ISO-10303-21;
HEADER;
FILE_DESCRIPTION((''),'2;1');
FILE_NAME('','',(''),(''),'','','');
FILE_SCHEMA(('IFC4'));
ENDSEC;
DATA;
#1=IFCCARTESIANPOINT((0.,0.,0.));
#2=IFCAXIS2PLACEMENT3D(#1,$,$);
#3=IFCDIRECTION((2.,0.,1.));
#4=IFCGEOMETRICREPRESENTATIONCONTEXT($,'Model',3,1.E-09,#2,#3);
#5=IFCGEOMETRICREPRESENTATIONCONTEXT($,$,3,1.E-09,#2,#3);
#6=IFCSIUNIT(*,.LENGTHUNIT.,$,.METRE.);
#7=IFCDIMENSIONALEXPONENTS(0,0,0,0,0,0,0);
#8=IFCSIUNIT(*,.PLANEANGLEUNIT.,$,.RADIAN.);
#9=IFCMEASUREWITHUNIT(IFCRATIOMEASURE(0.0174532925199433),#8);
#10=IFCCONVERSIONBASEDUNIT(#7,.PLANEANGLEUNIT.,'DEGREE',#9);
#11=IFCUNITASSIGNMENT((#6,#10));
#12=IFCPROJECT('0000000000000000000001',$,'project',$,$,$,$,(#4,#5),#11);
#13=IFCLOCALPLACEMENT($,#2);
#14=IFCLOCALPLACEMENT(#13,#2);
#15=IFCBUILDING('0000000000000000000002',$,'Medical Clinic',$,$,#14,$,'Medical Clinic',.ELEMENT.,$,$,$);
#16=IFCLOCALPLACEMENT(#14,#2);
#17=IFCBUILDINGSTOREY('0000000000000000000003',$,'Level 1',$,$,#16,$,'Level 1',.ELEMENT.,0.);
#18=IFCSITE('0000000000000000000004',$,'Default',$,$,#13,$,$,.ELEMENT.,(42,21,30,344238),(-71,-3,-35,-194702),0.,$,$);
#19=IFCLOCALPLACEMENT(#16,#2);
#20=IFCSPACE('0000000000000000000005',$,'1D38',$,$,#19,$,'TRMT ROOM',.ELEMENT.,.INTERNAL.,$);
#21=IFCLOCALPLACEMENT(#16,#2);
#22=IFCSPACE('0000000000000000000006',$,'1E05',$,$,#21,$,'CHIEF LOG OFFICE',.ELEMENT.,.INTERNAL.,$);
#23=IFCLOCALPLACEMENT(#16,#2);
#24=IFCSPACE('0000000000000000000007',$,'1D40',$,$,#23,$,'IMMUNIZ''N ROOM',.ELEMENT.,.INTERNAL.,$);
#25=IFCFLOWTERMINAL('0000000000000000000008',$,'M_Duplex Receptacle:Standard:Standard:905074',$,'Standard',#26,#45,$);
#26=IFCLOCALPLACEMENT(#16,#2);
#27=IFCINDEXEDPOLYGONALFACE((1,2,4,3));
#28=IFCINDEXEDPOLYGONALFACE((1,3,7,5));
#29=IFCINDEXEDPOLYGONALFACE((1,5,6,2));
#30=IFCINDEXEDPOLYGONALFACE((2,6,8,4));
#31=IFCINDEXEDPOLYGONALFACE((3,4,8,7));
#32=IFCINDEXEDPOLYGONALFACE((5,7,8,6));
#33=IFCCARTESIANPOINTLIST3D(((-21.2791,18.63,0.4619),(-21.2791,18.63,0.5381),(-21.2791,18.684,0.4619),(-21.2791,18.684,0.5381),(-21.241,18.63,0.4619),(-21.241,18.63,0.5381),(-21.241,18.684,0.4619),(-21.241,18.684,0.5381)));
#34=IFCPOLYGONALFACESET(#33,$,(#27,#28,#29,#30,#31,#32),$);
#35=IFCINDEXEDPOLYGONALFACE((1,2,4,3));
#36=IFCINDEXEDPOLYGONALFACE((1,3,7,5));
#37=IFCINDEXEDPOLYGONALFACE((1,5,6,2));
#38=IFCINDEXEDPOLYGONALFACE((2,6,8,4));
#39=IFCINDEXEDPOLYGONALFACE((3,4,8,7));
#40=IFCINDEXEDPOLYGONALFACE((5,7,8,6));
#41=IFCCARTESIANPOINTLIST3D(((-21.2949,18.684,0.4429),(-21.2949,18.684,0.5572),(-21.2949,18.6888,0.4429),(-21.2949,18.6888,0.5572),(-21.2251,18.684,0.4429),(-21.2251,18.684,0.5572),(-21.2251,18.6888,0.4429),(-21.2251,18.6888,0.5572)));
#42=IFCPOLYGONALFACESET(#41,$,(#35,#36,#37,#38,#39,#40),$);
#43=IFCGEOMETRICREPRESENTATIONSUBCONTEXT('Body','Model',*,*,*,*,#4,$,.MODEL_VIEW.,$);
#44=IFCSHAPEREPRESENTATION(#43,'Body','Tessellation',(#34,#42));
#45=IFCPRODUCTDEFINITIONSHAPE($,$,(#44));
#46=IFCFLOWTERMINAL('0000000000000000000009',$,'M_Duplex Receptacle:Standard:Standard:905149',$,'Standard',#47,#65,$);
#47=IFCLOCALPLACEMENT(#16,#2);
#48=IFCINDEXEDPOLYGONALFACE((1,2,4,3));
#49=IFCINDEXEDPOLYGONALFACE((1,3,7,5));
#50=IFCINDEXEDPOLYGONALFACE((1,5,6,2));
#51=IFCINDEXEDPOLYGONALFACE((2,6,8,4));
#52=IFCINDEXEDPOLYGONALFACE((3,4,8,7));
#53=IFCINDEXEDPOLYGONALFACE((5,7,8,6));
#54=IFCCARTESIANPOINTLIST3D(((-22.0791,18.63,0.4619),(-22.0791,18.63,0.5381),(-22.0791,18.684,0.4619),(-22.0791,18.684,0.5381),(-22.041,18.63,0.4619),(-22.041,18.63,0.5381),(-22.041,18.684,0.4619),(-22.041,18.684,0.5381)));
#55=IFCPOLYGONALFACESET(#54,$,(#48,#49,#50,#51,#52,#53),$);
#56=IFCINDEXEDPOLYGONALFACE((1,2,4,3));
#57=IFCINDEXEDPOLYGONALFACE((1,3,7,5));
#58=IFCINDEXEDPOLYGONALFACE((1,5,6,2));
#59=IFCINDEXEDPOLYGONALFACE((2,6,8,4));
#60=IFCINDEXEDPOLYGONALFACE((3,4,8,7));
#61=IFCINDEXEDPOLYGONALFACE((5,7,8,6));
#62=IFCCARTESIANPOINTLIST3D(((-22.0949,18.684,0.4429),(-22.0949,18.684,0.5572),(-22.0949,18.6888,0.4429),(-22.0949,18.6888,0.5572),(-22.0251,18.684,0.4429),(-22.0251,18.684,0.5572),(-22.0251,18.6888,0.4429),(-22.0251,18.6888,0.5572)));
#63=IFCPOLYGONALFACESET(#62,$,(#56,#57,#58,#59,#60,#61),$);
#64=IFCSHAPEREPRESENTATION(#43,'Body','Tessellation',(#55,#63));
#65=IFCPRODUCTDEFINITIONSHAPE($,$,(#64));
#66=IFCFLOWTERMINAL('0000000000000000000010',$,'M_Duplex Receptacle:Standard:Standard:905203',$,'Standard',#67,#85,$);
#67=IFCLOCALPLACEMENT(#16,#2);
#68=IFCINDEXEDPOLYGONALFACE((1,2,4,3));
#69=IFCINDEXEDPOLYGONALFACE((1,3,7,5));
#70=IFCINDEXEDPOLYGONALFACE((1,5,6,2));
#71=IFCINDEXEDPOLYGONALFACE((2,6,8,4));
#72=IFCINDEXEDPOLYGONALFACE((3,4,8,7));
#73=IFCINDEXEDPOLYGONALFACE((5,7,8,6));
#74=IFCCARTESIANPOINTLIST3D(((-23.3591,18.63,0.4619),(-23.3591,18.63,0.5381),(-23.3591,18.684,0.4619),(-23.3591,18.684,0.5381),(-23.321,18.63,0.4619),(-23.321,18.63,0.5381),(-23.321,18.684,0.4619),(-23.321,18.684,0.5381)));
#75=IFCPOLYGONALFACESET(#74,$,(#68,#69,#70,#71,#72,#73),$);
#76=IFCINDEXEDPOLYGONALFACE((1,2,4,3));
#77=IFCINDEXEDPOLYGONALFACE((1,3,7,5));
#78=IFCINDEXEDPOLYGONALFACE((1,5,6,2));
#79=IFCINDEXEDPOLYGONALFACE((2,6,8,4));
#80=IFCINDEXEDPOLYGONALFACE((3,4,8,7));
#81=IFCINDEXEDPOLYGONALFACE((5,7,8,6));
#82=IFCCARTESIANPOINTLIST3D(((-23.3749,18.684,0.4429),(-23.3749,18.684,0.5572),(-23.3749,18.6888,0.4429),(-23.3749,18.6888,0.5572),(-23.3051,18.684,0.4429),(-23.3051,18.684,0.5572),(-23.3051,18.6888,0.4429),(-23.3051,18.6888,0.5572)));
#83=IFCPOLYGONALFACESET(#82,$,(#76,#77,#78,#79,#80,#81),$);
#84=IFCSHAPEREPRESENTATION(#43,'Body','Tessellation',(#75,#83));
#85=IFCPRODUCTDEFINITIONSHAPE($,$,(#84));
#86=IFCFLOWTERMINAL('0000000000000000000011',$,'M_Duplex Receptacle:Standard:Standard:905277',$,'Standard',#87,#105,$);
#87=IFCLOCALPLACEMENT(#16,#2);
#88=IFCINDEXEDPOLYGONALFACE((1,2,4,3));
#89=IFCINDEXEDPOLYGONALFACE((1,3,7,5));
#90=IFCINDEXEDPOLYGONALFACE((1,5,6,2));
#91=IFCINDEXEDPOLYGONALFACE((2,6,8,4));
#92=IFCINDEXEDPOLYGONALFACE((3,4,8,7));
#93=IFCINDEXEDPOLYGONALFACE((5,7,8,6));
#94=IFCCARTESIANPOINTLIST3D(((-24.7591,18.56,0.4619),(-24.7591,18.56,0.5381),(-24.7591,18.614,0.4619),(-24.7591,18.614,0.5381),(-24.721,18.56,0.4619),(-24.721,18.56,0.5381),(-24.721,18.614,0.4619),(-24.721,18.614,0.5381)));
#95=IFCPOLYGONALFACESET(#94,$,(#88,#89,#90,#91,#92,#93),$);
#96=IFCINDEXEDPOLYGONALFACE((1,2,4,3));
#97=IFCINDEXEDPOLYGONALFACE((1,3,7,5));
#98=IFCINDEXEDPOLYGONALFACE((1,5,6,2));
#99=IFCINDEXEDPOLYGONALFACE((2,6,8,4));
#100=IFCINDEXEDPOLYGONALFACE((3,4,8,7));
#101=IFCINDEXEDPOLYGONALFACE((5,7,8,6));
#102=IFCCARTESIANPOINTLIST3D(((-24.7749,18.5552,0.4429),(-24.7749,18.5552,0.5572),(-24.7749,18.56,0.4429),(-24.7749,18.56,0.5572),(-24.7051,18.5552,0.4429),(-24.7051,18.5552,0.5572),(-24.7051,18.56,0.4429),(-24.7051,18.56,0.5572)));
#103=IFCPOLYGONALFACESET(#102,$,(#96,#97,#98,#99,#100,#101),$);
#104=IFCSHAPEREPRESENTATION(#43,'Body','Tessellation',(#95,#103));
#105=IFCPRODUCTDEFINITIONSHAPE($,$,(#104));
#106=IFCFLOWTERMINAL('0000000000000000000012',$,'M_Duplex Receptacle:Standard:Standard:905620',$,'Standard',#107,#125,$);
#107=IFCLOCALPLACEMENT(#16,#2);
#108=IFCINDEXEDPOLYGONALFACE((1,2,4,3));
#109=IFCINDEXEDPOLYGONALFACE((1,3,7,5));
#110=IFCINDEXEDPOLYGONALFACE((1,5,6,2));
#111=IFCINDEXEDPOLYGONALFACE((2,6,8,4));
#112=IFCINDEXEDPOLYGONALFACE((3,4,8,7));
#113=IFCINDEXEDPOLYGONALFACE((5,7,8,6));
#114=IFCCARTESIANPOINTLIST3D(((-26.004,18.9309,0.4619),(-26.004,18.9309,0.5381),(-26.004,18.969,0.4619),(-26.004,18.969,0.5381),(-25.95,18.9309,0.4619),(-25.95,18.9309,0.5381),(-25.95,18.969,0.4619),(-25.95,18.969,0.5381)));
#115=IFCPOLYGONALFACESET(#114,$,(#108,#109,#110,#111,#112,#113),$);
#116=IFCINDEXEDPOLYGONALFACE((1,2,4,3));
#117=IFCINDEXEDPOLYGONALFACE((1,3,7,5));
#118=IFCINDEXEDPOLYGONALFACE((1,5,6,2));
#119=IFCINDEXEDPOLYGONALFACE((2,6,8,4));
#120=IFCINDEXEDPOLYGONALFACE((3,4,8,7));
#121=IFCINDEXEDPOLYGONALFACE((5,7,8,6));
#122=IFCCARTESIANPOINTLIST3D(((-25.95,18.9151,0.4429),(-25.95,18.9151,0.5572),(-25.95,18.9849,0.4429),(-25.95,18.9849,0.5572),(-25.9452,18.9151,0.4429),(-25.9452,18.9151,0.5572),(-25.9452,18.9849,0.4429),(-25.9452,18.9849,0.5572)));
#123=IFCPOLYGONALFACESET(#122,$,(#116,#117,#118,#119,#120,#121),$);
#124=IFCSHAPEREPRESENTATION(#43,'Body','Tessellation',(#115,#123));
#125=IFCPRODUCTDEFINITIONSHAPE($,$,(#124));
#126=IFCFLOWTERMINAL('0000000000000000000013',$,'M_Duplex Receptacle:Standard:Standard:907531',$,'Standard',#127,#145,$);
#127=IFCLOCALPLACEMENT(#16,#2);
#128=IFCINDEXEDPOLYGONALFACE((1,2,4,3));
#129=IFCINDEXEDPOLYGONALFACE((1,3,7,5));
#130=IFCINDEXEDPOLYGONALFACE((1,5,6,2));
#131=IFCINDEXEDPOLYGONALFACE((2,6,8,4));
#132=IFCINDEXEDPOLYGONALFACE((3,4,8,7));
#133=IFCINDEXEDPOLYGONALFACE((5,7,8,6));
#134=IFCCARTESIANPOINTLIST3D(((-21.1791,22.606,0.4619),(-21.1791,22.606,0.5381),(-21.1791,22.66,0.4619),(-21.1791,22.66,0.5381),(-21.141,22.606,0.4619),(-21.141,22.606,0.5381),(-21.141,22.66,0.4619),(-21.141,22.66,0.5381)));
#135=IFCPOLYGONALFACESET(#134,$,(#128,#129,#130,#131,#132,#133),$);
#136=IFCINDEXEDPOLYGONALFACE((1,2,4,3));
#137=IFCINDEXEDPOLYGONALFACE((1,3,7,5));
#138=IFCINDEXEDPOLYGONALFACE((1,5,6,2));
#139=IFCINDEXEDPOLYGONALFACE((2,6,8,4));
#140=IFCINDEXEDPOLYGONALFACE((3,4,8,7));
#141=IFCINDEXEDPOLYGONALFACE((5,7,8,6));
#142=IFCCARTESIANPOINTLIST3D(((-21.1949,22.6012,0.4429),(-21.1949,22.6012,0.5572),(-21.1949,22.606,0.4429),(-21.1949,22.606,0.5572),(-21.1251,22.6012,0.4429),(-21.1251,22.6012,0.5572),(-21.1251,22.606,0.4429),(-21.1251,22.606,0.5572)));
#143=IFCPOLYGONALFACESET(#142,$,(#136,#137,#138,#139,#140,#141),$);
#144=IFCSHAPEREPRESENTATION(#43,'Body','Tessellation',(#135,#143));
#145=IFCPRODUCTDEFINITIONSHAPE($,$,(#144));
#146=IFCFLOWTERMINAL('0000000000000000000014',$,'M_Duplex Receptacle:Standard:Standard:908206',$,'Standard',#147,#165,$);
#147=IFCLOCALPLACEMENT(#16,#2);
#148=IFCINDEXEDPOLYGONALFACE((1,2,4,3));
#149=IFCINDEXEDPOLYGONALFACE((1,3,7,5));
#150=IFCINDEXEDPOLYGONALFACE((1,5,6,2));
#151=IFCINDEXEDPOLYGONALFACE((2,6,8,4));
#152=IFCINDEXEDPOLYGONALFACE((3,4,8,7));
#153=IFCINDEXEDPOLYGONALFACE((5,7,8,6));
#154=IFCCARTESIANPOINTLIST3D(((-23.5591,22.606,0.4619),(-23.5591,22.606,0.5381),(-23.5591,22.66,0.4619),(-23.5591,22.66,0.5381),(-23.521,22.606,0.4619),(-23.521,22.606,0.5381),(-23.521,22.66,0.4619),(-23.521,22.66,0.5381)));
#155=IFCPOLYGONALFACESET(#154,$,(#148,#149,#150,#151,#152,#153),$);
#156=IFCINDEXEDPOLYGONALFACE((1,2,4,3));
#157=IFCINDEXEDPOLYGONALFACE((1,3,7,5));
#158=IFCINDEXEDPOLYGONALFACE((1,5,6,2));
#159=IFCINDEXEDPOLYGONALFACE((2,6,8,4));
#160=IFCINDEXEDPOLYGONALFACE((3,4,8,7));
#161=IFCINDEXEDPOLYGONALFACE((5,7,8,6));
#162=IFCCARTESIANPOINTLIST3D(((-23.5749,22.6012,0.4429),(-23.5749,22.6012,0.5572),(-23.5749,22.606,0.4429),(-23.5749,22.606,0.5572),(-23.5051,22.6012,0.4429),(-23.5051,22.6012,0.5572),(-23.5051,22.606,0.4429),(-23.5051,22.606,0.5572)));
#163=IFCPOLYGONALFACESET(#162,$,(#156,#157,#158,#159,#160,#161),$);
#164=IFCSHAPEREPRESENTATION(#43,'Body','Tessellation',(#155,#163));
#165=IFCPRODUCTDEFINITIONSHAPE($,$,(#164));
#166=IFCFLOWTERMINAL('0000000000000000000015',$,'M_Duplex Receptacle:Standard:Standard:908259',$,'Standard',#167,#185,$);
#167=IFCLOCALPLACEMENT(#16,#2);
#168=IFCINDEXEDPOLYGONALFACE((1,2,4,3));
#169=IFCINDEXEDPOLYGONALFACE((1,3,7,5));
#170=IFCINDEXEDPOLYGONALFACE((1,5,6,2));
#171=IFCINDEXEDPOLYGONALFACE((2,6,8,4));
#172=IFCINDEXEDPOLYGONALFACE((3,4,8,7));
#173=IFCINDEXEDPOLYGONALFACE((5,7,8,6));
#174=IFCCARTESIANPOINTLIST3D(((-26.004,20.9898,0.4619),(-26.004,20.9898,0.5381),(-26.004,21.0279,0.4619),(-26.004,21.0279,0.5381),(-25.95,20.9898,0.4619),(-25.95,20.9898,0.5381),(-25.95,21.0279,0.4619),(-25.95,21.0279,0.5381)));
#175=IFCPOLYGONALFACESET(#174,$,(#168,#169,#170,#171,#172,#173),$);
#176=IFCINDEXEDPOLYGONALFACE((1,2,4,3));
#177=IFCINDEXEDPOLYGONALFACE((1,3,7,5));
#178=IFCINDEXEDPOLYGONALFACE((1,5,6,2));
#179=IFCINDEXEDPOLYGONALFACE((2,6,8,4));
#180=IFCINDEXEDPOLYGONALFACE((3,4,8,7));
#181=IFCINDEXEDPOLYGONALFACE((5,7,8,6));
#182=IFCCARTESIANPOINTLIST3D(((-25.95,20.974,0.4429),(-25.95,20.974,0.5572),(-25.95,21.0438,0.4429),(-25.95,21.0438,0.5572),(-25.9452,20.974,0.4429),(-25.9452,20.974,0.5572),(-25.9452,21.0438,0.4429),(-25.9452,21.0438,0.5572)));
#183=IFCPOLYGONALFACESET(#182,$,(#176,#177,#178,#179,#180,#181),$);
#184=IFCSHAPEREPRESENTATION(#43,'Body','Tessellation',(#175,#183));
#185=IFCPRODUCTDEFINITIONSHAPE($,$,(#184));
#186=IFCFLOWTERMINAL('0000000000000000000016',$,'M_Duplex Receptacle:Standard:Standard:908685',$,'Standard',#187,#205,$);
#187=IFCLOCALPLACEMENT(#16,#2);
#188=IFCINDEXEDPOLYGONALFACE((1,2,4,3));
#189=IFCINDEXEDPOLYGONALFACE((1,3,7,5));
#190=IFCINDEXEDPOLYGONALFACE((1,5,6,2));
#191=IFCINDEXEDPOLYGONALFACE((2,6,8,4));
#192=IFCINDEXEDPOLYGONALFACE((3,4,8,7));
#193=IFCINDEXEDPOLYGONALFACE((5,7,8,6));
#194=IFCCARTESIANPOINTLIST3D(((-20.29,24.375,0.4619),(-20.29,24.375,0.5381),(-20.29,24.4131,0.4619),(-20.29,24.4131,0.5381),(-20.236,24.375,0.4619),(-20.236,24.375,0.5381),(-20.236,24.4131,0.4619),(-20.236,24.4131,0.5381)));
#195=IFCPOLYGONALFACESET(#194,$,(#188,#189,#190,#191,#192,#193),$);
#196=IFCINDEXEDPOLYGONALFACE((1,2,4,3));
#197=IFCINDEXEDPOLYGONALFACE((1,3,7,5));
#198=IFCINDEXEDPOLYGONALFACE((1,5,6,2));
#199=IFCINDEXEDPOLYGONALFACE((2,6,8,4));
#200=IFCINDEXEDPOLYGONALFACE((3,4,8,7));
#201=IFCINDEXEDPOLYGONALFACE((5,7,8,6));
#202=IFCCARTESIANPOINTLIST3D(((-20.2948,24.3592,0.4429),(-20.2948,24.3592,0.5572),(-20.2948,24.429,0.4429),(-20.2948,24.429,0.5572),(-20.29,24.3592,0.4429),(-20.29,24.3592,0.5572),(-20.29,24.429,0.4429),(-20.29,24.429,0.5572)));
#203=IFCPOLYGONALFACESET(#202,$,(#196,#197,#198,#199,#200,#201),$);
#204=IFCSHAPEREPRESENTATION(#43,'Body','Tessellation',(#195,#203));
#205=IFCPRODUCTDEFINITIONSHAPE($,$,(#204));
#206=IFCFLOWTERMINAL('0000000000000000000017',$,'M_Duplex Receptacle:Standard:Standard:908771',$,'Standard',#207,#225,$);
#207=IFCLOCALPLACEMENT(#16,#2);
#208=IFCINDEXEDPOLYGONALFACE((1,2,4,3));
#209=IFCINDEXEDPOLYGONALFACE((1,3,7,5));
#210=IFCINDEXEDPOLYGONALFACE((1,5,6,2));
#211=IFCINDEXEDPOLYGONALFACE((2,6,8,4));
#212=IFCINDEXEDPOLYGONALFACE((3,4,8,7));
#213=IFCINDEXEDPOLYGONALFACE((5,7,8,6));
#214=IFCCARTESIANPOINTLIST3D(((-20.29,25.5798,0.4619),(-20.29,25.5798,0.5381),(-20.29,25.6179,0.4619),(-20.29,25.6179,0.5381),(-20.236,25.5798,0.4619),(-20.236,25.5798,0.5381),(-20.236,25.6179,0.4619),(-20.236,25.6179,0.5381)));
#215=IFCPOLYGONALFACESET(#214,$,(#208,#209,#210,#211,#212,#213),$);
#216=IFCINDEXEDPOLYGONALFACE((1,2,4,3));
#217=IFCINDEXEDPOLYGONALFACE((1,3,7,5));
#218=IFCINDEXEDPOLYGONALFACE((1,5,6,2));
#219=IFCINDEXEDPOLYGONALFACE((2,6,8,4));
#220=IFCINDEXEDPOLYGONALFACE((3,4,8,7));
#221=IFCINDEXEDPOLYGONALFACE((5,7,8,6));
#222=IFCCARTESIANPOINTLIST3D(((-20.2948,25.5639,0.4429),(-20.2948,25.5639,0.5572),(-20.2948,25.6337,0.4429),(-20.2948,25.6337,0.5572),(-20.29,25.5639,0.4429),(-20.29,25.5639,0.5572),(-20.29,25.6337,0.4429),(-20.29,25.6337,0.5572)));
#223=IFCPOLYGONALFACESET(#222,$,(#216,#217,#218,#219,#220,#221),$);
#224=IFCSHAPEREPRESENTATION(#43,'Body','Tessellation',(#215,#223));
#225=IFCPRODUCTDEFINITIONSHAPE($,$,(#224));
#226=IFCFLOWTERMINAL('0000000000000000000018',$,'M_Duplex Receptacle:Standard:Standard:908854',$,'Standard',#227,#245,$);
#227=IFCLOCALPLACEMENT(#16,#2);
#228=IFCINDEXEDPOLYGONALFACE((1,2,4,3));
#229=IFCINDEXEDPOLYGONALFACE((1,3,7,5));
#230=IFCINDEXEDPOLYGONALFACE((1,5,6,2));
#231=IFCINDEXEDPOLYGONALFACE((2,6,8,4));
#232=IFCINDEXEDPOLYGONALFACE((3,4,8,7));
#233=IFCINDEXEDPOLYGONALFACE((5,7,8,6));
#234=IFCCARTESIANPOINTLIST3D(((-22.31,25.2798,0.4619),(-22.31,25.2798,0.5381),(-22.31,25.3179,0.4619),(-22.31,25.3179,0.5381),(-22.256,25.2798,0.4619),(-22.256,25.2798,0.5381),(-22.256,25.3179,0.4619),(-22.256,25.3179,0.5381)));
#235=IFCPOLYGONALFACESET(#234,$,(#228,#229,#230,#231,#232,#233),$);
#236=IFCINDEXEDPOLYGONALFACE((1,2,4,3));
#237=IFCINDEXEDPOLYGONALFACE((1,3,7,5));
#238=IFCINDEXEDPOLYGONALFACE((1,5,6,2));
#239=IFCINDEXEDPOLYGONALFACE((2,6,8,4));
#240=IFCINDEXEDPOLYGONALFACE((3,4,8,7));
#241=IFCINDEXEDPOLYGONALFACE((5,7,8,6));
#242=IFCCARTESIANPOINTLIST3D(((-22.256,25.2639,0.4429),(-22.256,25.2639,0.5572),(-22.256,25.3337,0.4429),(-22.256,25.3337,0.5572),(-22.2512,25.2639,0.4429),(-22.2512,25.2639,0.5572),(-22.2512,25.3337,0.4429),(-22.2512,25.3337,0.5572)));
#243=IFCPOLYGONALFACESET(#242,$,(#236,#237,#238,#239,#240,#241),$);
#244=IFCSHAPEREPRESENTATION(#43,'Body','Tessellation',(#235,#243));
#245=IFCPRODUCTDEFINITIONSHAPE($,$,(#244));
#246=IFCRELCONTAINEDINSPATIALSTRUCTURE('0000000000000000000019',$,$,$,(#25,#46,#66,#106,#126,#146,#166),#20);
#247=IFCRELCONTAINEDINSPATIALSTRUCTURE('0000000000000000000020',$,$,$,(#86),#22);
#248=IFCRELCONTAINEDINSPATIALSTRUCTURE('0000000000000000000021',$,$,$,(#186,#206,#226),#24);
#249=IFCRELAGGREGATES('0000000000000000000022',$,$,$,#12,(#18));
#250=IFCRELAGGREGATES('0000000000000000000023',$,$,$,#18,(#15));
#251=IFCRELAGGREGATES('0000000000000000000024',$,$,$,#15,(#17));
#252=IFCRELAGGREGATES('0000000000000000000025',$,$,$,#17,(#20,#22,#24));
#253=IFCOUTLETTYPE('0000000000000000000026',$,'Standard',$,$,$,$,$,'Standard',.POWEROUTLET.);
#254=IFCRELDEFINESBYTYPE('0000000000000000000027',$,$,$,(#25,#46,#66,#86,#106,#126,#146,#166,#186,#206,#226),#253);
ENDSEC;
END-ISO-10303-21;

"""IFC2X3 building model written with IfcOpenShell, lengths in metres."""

from ifc_helpers import new_model, entity, si_unit, converted_unit, direction, frame, frame_2d, origin, origin_2d_with_axis, place, context, subcontext, project, spatial, rectangle, extrude, source, transform, mapped, type_object, type_shapes, element, save


model = new_model("IFC2X3")

# Units and contexts
model_context = context("Model", 3, precision=1e-09, world=origin(), true_north=direction((2.0, 0.0, 1.0)))
context_of_model = context(None, 3, precision=1e-09, world=origin(), true_north=direction((2.0, 0.0, 1.0)))
body_context = subcontext(model_context, "Body", "Model", "MODEL_VIEW")
ifc_project = project(units=[si_unit("LENGTHUNIT", "METRE"), converted_unit("PLANEANGLEUNIT", "DEGREE", entity("IfcRatioMeasure", 0.0174532925199433), si_unit("PLANEANGLEUNIT", "RADIAN"), dimensions=[0, 0, 0, 0, 0, 0, 0])], contexts=[model_context, context_of_model])

# Site, building, storey, space
site_placement = place(None, origin())
site = spatial("IfcSite", under=ifc_project, at=site_placement, Name="Default", CompositionType="ELEMENT", RefLatitude=(42, 21, 30, 344238), RefLongitude=(-71, -3, -35, -194702), RefElevation=0.0)
building_placement = place(site_placement, origin())
building = spatial("IfcBuilding", under=site, at=building_placement, Name="Medical Clinic", LongName="Medical Clinic", CompositionType="ELEMENT")
storey_placement = place(building_placement, origin())
storey = spatial("IfcBuildingStorey", under=building, at=storey_placement, Name="Level 1", LongName="Level 1", CompositionType="ELEMENT", Elevation=0.0)
space_1_placement = place(storey_placement, origin())
space_1 = spatial("IfcSpace", under=storey, at=space_1_placement, Name="1D38", LongName="TRMT ROOM", CompositionType="ELEMENT", InteriorOrExteriorSpace="INTERNAL")

# Flow terminals
outlet_type = type_object("IfcOutletType", Name="Standard", ElementType="Standard", PredefinedType="POWEROUTLET")
shared_shape_1 = source(origin(), body_context, "Body", "SweptSolid", [
    extrude(rectangle(XDim=0.0381, YDim=0.0762, at=origin_2d_with_axis()), frame((0.0, 0.0, -0.054), z_axis=(0.0, 0.0, 1.0), x_axis=(-1.0, 0.0, 0.0)), (0.0, 0.0, 1.0), 0.054),
    extrude(rectangle(XDim=0.0698, YDim=0.1143, at=frame_2d((0.0, 0.0), x_axis=(1.0, 0.0))), frame((0.0, 0.0, 0.0), z_axis=(0.0, 0.0, 1.0), x_axis=(-1.0, 0.0, 0.0)), (0.0, 0.0, 1.0), 0.0048),
])
type_shapes(outlet_type, [shared_shape_1])
for number, where, z_axis, x_axis, name in (
    (1, (-21.26, 18.684, 0.5), (0.0, 1.0, 0.0), (-1.0, 0.0, 0.0), "M_Duplex Receptacle:Standard:Standard:905074"),
    (2, (-22.06, 18.684, 0.5), (0.0, 1.0, 0.0), (-1.0, 0.0, 0.0), "M_Duplex Receptacle:Standard:Standard:905149"),
    (3, (-23.34, 18.684, 0.5), (0.0, 1.0, 0.0), (-1.0, 0.0, 0.0), "M_Duplex Receptacle:Standard:Standard:905203"),
):
    element("IfcFlowTerminal", number, at=place(space_1_placement, frame(where, z_axis=z_axis, x_axis=x_axis)), inside=space_1, type_object=outlet_type, Name=name, ObjectType="Standard", context=body_context, shape_type="MappedRepresentation", body=[
        mapped(shared_shape_1, transform((0.0, 0.0, 0.0), scale=1.0)),
    ])

# Shared definitions
space_2_placement = place(storey_placement, origin())
space_2 = spatial("IfcSpace", under=storey, at=space_2_placement, Name="1E05", LongName="CHIEF LOG OFFICE", CompositionType="ELEMENT", InteriorOrExteriorSpace="INTERNAL")

# Flow terminals
flow_terminal_1_placement = place(space_2_placement, frame((-24.74, 18.56, 0.5), z_axis=(0.0, -1.0, 0.0), x_axis=(1.0, 0.0, 0.0)))
element("IfcFlowTerminal", 4, at=flow_terminal_1_placement, inside=space_2, type_object=outlet_type, Name="M_Duplex Receptacle:Standard:Standard:905277", ObjectType="Standard", context=body_context, shape_type="MappedRepresentation", body=[
    mapped(shared_shape_1, transform((0.0, 0.0, 0.0), scale=1.0)),
])
for number, where, z_axis, x_axis, name in (
    (5, (-25.95, 18.95, 0.5), (1.0, 0.0, 0.0), (0.0, 1.0, 0.0), "M_Duplex Receptacle:Standard:Standard:905620"),
    (6, (-21.16, 22.606, 0.5), (0.0, -1.0, 0.0), (1.0, 0.0, 0.0), "M_Duplex Receptacle:Standard:Standard:907531"),
    (7, (-23.54, 22.606, 0.5), (0.0, -1.0, 0.0), (1.0, 0.0, 0.0), "M_Duplex Receptacle:Standard:Standard:908206"),
    (8, (-25.95, 21.0089, 0.5), (1.0, 0.0, 0.0), (0.0, 1.0, 0.0), "M_Duplex Receptacle:Standard:Standard:908259"),
):
    element("IfcFlowTerminal", number, at=place(space_1_placement, frame(where, z_axis=z_axis, x_axis=x_axis)), inside=space_1, type_object=outlet_type, Name=name, ObjectType="Standard", context=body_context, shape_type="MappedRepresentation", body=[
        mapped(shared_shape_1, transform((0.0, 0.0, 0.0), scale=1.0)),
    ])

# Shared definitions
space_3_placement = place(storey_placement, origin())
space_3 = spatial("IfcSpace", under=storey, at=space_3_placement, Name="1D40", LongName="IMMUNIZ'N ROOM", CompositionType="ELEMENT", InteriorOrExteriorSpace="INTERNAL")

# Flow terminals
for number, where, z_axis, x_axis, name in (
    (9, (-20.29, 24.3941, 0.5), (-1.0, 0.0, 0.0), (0.0, -1.0, 0.0), "M_Duplex Receptacle:Standard:Standard:908685"),
    (10, (-20.29, 25.5988, 0.5), (-1.0, 0.0, 0.0), (0.0, -1.0, 0.0), "M_Duplex Receptacle:Standard:Standard:908771"),
    (11, (-22.256, 25.2988, 0.5), (1.0, 0.0, 0.0), (0.0, 1.0, 0.0), "M_Duplex Receptacle:Standard:Standard:908854"),
):
    element("IfcFlowTerminal", number, at=place(space_3_placement, frame(where, z_axis=z_axis, x_axis=x_axis)), inside=space_3, type_object=outlet_type, Name=name, ObjectType="Standard", context=body_context, shape_type="MappedRepresentation", body=[
        mapped(shared_shape_1, transform((0.0, 0.0, 0.0), scale=1.0)),
    ])

save(model, "model.ifc")
